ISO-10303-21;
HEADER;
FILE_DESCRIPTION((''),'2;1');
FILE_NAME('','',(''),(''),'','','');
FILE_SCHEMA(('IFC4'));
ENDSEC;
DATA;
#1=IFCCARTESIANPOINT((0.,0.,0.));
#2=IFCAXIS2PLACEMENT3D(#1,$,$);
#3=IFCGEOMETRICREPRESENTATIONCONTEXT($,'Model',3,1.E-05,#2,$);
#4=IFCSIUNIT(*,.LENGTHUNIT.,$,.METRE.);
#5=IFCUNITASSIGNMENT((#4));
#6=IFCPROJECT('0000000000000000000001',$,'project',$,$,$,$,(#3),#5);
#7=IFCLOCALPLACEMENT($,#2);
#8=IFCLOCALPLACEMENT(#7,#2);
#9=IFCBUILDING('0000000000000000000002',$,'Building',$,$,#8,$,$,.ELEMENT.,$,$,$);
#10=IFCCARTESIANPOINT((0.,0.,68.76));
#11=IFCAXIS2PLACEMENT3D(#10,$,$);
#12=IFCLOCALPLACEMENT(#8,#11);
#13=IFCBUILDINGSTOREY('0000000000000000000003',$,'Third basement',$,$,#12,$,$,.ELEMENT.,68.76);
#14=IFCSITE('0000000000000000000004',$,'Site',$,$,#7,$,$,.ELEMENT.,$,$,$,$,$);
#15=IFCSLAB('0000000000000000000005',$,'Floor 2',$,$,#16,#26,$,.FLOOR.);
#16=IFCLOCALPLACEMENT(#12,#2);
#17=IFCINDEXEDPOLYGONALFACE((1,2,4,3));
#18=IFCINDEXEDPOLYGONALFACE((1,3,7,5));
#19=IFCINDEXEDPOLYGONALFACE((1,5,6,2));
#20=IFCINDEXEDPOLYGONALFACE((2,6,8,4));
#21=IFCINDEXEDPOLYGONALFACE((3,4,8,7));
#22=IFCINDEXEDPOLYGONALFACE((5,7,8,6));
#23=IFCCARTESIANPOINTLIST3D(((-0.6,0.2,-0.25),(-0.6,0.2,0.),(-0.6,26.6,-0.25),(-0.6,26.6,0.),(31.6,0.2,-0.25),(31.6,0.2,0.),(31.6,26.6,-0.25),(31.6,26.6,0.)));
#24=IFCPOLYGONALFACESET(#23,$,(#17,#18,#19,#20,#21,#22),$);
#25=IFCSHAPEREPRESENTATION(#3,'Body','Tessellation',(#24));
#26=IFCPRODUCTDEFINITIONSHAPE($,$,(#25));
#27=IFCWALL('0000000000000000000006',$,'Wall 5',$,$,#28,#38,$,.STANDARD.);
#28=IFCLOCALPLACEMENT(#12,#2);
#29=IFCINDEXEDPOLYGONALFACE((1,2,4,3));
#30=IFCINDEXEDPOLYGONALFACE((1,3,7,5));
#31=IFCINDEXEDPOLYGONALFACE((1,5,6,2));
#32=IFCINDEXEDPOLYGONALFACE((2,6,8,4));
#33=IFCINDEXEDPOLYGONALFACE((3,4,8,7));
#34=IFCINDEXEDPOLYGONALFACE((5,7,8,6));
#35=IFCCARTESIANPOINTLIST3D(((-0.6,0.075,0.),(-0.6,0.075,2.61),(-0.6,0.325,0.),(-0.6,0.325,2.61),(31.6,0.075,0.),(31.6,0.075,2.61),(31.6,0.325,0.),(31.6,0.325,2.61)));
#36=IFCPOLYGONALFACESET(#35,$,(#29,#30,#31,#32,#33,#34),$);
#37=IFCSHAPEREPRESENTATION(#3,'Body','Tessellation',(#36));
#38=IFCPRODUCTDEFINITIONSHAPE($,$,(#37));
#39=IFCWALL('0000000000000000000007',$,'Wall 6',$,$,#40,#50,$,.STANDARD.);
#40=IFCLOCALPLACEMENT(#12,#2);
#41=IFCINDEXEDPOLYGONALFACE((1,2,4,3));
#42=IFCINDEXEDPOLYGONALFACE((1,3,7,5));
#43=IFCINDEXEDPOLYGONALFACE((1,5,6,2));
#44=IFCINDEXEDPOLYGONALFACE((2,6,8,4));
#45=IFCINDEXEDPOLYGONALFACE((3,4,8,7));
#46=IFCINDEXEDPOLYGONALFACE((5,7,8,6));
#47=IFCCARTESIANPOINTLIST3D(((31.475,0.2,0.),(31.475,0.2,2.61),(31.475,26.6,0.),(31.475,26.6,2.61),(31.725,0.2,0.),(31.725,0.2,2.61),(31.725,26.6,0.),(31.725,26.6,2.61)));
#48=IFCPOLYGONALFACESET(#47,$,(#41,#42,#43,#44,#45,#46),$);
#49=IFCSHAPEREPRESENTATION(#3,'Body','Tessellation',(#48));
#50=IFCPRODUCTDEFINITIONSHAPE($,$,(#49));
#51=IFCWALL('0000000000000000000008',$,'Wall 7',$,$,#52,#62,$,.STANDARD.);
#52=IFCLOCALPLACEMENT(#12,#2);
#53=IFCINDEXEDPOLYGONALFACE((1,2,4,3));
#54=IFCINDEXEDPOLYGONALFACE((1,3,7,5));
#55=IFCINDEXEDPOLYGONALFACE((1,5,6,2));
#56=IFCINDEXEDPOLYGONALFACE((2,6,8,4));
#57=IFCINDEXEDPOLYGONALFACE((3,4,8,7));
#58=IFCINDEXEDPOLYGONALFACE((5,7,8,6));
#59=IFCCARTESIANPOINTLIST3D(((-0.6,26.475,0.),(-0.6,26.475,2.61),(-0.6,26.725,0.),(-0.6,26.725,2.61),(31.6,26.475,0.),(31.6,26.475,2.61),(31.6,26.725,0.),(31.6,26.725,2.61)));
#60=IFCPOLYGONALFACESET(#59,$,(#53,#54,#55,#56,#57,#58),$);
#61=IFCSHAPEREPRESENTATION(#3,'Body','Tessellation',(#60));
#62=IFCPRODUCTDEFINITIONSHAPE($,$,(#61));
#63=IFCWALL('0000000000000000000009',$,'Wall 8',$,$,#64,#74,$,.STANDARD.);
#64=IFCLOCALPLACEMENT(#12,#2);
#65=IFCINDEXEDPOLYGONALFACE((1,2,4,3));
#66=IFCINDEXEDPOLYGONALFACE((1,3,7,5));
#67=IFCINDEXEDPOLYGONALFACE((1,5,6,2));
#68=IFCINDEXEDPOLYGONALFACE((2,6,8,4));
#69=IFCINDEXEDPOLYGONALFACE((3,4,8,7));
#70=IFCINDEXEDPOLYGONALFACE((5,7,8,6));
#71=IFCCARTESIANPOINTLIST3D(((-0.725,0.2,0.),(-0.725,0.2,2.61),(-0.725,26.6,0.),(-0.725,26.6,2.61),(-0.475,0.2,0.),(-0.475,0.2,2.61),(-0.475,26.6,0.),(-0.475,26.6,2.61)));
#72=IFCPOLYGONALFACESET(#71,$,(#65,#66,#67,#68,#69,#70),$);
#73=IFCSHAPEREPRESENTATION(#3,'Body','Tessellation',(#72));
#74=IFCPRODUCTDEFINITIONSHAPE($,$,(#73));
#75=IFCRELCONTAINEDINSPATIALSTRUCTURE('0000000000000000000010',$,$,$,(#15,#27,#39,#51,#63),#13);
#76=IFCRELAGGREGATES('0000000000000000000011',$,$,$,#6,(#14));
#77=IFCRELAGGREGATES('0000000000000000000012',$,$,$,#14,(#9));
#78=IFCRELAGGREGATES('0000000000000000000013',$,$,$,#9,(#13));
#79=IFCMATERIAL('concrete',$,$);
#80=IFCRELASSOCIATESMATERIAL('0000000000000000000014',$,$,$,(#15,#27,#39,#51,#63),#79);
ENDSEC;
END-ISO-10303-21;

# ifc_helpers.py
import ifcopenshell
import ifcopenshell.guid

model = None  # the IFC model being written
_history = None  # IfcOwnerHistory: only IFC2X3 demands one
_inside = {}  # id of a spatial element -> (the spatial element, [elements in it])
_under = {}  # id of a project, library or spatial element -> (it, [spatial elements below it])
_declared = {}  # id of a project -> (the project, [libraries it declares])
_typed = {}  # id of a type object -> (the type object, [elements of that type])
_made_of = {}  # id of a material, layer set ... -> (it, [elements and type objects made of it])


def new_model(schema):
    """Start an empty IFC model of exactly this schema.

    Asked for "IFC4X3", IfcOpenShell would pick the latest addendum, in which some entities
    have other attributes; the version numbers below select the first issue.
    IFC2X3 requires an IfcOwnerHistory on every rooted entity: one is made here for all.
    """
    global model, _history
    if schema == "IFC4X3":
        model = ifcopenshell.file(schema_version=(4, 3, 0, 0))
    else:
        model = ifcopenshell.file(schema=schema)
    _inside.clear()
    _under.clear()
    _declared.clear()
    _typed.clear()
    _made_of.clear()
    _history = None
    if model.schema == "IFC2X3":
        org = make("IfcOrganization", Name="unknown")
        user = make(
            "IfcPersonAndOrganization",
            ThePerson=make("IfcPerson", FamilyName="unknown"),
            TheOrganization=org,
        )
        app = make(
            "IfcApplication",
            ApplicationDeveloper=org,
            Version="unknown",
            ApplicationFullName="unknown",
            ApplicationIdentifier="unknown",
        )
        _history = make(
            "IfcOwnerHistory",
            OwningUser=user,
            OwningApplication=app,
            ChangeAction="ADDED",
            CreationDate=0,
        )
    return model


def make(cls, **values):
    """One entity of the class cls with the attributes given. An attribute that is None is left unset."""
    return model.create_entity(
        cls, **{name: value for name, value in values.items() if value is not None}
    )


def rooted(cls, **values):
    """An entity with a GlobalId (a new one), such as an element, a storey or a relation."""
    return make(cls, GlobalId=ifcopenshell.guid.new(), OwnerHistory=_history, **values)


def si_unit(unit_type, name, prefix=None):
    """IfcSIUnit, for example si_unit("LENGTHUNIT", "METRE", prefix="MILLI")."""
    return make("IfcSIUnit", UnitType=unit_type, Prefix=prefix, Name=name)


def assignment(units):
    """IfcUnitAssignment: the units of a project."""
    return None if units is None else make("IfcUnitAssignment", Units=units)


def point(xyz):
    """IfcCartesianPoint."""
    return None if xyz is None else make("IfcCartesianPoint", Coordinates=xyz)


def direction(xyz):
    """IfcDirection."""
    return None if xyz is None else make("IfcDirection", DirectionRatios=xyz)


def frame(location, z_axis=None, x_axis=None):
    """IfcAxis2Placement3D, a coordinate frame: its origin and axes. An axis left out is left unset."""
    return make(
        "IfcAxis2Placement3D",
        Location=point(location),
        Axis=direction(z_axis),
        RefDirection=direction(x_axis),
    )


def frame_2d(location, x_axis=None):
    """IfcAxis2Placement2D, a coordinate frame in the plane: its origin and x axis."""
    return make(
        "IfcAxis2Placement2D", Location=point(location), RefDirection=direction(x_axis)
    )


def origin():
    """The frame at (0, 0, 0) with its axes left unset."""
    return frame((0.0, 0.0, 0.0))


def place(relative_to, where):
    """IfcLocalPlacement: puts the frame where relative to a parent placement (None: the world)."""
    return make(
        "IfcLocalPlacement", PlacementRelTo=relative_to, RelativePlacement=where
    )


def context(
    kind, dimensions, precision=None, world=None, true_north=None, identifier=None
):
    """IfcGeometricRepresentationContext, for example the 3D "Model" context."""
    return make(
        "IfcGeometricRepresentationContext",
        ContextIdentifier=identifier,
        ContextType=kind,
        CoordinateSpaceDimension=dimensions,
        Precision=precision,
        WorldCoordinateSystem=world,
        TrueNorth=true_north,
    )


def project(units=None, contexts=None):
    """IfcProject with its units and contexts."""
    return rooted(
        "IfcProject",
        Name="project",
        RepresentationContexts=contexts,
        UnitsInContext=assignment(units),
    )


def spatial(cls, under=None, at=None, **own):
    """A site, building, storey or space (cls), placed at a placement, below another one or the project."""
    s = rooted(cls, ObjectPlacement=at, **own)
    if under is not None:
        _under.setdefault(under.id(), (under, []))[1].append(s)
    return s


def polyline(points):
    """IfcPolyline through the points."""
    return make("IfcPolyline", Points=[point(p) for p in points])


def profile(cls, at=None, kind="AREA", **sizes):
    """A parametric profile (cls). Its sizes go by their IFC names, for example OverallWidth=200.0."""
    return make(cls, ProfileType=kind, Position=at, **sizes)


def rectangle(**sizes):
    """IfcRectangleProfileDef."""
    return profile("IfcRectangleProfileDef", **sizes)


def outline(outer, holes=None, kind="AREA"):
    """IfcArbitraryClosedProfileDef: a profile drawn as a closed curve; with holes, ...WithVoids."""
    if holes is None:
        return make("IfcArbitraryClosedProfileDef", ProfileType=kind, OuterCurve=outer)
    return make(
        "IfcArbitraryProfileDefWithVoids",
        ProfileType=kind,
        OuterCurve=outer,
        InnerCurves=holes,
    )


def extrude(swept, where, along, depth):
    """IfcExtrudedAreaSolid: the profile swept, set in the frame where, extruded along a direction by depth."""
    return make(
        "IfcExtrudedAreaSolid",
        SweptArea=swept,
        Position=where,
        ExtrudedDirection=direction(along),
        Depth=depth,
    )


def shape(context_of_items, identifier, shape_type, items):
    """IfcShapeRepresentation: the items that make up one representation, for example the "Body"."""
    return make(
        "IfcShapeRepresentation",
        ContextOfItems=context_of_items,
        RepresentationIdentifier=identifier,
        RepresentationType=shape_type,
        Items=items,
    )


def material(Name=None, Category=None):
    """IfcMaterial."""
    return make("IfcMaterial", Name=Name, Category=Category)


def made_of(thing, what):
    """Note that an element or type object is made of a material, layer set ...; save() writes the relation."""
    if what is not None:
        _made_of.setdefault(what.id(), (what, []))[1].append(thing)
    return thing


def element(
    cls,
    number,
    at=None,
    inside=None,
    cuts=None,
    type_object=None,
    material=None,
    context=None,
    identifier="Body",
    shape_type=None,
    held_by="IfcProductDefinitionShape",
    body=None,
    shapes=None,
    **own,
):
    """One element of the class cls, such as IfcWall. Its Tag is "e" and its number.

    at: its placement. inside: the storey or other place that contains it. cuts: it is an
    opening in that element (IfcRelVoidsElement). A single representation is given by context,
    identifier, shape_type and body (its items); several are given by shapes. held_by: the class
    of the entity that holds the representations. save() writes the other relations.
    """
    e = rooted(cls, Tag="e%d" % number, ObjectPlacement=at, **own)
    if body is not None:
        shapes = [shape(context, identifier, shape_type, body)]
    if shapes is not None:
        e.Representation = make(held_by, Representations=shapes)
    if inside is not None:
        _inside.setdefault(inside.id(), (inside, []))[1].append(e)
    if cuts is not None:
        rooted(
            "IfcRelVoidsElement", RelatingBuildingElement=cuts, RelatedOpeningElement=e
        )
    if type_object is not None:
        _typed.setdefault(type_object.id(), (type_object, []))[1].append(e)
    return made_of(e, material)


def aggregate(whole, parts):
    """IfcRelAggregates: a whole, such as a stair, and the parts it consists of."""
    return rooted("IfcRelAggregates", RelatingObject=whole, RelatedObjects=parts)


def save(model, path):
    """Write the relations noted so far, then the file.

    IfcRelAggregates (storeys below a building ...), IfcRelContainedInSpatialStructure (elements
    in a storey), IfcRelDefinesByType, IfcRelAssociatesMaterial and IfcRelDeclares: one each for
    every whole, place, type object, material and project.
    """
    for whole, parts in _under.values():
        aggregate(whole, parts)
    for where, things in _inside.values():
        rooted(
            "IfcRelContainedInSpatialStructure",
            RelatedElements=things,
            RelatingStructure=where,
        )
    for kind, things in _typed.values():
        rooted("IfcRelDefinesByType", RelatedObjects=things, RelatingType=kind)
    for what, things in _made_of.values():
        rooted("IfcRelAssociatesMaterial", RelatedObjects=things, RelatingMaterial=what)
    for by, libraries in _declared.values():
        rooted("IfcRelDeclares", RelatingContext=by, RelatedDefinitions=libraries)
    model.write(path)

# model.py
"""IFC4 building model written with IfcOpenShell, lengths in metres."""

from ifc_helpers import new_model, si_unit, frame, frame_2d, origin, place, context, project, spatial, polyline, rectangle, outline, extrude, material, element, save


model = new_model("IFC4")

# Units and contexts
model_context = context("Model", 3, precision=1e-05, world=origin())
ifc_project = project(units=[si_unit("LENGTHUNIT", "METRE")], contexts=[model_context])

# Site, building, storey
site_placement = place(None, origin())
site = spatial("IfcSite", under=ifc_project, at=site_placement, Name="Site", CompositionType="ELEMENT")
building_placement = place(site_placement, origin())
building = spatial("IfcBuilding", under=site, at=building_placement, Name="Building", CompositionType="ELEMENT")
storey_placement = place(building_placement, frame((0.0, 0.0, 68.76)))
storey = spatial("IfcBuildingStorey", under=building, at=storey_placement, Name="Third basement", CompositionType="ELEMENT", Elevation=68.76)

# Slab
ifc_material = material(Name="concrete")
slab_placement = place(storey_placement, frame((0.0, 0.0, -0.25), z_axis=(0.0, 0.0, 1.0), x_axis=(1.0, 0.0, 0.0)))
element("IfcSlab", 1, at=slab_placement, inside=storey, material=ifc_material, Name="Floor 2", PredefinedType="FLOOR", context=model_context, shape_type="SweptSolid", body=[
    extrude(outline(polyline([(-0.6, 0.2), (31.6, 0.2), (31.6, 26.6), (-0.6, 26.6), (-0.6, 0.2)])), origin(), (0.0, 0.0, 1.0), 0.25),
])

# Walls
wall_1_placement = place(storey_placement, frame((-0.6, 0.2, 0.0), z_axis=(0.0, 0.0, 1.0), x_axis=(1.0, 0.0, 0.0)))
element("IfcWall", 2, at=wall_1_placement, inside=storey, material=ifc_material, Name="Wall 5", PredefinedType="STANDARD", context=model_context, shape_type="SweptSolid", body=[
    extrude(rectangle(XDim=32.2, YDim=0.25, at=frame_2d((16.1, 0.0))), origin(), (0.0, 0.0, 1.0), 2.61),
])
wall_2_placement = place(storey_placement, frame((31.6, 0.2, 0.0), z_axis=(0.0, 0.0, 1.0), x_axis=(0.0, 1.0, 0.0)))
element("IfcWall", 3, at=wall_2_placement, inside=storey, material=ifc_material, Name="Wall 6", PredefinedType="STANDARD", context=model_context, shape_type="SweptSolid", body=[
    extrude(rectangle(XDim=26.4, YDim=0.25, at=frame_2d((13.2, 0.0))), origin(), (0.0, 0.0, 1.0), 2.61),
])
wall_3_placement = place(storey_placement, frame((31.6, 26.6, 0.0), z_axis=(0.0, 0.0, 1.0), x_axis=(-1.0, 0.0, 0.0)))
element("IfcWall", 4, at=wall_3_placement, inside=storey, material=ifc_material, Name="Wall 7", PredefinedType="STANDARD", context=model_context, shape_type="SweptSolid", body=[
    extrude(rectangle(XDim=32.2, YDim=0.25, at=frame_2d((16.1, 0.0))), origin(), (0.0, 0.0, 1.0), 2.61),
])
wall_4_placement = place(storey_placement, frame((-0.6, 26.6, 0.0), z_axis=(0.0, 0.0, 1.0), x_axis=(0.0, -1.0, 0.0)))
element("IfcWall", 5, at=wall_4_placement, inside=storey, material=ifc_material, Name="Wall 8", PredefinedType="STANDARD", context=model_context, shape_type="SweptSolid", body=[
    extrude(rectangle(XDim=26.4, YDim=0.25, at=frame_2d((13.2, 0.0))), origin(), (0.0, 0.0, 1.0), 2.61),
])

save(model, "model.ifc")
